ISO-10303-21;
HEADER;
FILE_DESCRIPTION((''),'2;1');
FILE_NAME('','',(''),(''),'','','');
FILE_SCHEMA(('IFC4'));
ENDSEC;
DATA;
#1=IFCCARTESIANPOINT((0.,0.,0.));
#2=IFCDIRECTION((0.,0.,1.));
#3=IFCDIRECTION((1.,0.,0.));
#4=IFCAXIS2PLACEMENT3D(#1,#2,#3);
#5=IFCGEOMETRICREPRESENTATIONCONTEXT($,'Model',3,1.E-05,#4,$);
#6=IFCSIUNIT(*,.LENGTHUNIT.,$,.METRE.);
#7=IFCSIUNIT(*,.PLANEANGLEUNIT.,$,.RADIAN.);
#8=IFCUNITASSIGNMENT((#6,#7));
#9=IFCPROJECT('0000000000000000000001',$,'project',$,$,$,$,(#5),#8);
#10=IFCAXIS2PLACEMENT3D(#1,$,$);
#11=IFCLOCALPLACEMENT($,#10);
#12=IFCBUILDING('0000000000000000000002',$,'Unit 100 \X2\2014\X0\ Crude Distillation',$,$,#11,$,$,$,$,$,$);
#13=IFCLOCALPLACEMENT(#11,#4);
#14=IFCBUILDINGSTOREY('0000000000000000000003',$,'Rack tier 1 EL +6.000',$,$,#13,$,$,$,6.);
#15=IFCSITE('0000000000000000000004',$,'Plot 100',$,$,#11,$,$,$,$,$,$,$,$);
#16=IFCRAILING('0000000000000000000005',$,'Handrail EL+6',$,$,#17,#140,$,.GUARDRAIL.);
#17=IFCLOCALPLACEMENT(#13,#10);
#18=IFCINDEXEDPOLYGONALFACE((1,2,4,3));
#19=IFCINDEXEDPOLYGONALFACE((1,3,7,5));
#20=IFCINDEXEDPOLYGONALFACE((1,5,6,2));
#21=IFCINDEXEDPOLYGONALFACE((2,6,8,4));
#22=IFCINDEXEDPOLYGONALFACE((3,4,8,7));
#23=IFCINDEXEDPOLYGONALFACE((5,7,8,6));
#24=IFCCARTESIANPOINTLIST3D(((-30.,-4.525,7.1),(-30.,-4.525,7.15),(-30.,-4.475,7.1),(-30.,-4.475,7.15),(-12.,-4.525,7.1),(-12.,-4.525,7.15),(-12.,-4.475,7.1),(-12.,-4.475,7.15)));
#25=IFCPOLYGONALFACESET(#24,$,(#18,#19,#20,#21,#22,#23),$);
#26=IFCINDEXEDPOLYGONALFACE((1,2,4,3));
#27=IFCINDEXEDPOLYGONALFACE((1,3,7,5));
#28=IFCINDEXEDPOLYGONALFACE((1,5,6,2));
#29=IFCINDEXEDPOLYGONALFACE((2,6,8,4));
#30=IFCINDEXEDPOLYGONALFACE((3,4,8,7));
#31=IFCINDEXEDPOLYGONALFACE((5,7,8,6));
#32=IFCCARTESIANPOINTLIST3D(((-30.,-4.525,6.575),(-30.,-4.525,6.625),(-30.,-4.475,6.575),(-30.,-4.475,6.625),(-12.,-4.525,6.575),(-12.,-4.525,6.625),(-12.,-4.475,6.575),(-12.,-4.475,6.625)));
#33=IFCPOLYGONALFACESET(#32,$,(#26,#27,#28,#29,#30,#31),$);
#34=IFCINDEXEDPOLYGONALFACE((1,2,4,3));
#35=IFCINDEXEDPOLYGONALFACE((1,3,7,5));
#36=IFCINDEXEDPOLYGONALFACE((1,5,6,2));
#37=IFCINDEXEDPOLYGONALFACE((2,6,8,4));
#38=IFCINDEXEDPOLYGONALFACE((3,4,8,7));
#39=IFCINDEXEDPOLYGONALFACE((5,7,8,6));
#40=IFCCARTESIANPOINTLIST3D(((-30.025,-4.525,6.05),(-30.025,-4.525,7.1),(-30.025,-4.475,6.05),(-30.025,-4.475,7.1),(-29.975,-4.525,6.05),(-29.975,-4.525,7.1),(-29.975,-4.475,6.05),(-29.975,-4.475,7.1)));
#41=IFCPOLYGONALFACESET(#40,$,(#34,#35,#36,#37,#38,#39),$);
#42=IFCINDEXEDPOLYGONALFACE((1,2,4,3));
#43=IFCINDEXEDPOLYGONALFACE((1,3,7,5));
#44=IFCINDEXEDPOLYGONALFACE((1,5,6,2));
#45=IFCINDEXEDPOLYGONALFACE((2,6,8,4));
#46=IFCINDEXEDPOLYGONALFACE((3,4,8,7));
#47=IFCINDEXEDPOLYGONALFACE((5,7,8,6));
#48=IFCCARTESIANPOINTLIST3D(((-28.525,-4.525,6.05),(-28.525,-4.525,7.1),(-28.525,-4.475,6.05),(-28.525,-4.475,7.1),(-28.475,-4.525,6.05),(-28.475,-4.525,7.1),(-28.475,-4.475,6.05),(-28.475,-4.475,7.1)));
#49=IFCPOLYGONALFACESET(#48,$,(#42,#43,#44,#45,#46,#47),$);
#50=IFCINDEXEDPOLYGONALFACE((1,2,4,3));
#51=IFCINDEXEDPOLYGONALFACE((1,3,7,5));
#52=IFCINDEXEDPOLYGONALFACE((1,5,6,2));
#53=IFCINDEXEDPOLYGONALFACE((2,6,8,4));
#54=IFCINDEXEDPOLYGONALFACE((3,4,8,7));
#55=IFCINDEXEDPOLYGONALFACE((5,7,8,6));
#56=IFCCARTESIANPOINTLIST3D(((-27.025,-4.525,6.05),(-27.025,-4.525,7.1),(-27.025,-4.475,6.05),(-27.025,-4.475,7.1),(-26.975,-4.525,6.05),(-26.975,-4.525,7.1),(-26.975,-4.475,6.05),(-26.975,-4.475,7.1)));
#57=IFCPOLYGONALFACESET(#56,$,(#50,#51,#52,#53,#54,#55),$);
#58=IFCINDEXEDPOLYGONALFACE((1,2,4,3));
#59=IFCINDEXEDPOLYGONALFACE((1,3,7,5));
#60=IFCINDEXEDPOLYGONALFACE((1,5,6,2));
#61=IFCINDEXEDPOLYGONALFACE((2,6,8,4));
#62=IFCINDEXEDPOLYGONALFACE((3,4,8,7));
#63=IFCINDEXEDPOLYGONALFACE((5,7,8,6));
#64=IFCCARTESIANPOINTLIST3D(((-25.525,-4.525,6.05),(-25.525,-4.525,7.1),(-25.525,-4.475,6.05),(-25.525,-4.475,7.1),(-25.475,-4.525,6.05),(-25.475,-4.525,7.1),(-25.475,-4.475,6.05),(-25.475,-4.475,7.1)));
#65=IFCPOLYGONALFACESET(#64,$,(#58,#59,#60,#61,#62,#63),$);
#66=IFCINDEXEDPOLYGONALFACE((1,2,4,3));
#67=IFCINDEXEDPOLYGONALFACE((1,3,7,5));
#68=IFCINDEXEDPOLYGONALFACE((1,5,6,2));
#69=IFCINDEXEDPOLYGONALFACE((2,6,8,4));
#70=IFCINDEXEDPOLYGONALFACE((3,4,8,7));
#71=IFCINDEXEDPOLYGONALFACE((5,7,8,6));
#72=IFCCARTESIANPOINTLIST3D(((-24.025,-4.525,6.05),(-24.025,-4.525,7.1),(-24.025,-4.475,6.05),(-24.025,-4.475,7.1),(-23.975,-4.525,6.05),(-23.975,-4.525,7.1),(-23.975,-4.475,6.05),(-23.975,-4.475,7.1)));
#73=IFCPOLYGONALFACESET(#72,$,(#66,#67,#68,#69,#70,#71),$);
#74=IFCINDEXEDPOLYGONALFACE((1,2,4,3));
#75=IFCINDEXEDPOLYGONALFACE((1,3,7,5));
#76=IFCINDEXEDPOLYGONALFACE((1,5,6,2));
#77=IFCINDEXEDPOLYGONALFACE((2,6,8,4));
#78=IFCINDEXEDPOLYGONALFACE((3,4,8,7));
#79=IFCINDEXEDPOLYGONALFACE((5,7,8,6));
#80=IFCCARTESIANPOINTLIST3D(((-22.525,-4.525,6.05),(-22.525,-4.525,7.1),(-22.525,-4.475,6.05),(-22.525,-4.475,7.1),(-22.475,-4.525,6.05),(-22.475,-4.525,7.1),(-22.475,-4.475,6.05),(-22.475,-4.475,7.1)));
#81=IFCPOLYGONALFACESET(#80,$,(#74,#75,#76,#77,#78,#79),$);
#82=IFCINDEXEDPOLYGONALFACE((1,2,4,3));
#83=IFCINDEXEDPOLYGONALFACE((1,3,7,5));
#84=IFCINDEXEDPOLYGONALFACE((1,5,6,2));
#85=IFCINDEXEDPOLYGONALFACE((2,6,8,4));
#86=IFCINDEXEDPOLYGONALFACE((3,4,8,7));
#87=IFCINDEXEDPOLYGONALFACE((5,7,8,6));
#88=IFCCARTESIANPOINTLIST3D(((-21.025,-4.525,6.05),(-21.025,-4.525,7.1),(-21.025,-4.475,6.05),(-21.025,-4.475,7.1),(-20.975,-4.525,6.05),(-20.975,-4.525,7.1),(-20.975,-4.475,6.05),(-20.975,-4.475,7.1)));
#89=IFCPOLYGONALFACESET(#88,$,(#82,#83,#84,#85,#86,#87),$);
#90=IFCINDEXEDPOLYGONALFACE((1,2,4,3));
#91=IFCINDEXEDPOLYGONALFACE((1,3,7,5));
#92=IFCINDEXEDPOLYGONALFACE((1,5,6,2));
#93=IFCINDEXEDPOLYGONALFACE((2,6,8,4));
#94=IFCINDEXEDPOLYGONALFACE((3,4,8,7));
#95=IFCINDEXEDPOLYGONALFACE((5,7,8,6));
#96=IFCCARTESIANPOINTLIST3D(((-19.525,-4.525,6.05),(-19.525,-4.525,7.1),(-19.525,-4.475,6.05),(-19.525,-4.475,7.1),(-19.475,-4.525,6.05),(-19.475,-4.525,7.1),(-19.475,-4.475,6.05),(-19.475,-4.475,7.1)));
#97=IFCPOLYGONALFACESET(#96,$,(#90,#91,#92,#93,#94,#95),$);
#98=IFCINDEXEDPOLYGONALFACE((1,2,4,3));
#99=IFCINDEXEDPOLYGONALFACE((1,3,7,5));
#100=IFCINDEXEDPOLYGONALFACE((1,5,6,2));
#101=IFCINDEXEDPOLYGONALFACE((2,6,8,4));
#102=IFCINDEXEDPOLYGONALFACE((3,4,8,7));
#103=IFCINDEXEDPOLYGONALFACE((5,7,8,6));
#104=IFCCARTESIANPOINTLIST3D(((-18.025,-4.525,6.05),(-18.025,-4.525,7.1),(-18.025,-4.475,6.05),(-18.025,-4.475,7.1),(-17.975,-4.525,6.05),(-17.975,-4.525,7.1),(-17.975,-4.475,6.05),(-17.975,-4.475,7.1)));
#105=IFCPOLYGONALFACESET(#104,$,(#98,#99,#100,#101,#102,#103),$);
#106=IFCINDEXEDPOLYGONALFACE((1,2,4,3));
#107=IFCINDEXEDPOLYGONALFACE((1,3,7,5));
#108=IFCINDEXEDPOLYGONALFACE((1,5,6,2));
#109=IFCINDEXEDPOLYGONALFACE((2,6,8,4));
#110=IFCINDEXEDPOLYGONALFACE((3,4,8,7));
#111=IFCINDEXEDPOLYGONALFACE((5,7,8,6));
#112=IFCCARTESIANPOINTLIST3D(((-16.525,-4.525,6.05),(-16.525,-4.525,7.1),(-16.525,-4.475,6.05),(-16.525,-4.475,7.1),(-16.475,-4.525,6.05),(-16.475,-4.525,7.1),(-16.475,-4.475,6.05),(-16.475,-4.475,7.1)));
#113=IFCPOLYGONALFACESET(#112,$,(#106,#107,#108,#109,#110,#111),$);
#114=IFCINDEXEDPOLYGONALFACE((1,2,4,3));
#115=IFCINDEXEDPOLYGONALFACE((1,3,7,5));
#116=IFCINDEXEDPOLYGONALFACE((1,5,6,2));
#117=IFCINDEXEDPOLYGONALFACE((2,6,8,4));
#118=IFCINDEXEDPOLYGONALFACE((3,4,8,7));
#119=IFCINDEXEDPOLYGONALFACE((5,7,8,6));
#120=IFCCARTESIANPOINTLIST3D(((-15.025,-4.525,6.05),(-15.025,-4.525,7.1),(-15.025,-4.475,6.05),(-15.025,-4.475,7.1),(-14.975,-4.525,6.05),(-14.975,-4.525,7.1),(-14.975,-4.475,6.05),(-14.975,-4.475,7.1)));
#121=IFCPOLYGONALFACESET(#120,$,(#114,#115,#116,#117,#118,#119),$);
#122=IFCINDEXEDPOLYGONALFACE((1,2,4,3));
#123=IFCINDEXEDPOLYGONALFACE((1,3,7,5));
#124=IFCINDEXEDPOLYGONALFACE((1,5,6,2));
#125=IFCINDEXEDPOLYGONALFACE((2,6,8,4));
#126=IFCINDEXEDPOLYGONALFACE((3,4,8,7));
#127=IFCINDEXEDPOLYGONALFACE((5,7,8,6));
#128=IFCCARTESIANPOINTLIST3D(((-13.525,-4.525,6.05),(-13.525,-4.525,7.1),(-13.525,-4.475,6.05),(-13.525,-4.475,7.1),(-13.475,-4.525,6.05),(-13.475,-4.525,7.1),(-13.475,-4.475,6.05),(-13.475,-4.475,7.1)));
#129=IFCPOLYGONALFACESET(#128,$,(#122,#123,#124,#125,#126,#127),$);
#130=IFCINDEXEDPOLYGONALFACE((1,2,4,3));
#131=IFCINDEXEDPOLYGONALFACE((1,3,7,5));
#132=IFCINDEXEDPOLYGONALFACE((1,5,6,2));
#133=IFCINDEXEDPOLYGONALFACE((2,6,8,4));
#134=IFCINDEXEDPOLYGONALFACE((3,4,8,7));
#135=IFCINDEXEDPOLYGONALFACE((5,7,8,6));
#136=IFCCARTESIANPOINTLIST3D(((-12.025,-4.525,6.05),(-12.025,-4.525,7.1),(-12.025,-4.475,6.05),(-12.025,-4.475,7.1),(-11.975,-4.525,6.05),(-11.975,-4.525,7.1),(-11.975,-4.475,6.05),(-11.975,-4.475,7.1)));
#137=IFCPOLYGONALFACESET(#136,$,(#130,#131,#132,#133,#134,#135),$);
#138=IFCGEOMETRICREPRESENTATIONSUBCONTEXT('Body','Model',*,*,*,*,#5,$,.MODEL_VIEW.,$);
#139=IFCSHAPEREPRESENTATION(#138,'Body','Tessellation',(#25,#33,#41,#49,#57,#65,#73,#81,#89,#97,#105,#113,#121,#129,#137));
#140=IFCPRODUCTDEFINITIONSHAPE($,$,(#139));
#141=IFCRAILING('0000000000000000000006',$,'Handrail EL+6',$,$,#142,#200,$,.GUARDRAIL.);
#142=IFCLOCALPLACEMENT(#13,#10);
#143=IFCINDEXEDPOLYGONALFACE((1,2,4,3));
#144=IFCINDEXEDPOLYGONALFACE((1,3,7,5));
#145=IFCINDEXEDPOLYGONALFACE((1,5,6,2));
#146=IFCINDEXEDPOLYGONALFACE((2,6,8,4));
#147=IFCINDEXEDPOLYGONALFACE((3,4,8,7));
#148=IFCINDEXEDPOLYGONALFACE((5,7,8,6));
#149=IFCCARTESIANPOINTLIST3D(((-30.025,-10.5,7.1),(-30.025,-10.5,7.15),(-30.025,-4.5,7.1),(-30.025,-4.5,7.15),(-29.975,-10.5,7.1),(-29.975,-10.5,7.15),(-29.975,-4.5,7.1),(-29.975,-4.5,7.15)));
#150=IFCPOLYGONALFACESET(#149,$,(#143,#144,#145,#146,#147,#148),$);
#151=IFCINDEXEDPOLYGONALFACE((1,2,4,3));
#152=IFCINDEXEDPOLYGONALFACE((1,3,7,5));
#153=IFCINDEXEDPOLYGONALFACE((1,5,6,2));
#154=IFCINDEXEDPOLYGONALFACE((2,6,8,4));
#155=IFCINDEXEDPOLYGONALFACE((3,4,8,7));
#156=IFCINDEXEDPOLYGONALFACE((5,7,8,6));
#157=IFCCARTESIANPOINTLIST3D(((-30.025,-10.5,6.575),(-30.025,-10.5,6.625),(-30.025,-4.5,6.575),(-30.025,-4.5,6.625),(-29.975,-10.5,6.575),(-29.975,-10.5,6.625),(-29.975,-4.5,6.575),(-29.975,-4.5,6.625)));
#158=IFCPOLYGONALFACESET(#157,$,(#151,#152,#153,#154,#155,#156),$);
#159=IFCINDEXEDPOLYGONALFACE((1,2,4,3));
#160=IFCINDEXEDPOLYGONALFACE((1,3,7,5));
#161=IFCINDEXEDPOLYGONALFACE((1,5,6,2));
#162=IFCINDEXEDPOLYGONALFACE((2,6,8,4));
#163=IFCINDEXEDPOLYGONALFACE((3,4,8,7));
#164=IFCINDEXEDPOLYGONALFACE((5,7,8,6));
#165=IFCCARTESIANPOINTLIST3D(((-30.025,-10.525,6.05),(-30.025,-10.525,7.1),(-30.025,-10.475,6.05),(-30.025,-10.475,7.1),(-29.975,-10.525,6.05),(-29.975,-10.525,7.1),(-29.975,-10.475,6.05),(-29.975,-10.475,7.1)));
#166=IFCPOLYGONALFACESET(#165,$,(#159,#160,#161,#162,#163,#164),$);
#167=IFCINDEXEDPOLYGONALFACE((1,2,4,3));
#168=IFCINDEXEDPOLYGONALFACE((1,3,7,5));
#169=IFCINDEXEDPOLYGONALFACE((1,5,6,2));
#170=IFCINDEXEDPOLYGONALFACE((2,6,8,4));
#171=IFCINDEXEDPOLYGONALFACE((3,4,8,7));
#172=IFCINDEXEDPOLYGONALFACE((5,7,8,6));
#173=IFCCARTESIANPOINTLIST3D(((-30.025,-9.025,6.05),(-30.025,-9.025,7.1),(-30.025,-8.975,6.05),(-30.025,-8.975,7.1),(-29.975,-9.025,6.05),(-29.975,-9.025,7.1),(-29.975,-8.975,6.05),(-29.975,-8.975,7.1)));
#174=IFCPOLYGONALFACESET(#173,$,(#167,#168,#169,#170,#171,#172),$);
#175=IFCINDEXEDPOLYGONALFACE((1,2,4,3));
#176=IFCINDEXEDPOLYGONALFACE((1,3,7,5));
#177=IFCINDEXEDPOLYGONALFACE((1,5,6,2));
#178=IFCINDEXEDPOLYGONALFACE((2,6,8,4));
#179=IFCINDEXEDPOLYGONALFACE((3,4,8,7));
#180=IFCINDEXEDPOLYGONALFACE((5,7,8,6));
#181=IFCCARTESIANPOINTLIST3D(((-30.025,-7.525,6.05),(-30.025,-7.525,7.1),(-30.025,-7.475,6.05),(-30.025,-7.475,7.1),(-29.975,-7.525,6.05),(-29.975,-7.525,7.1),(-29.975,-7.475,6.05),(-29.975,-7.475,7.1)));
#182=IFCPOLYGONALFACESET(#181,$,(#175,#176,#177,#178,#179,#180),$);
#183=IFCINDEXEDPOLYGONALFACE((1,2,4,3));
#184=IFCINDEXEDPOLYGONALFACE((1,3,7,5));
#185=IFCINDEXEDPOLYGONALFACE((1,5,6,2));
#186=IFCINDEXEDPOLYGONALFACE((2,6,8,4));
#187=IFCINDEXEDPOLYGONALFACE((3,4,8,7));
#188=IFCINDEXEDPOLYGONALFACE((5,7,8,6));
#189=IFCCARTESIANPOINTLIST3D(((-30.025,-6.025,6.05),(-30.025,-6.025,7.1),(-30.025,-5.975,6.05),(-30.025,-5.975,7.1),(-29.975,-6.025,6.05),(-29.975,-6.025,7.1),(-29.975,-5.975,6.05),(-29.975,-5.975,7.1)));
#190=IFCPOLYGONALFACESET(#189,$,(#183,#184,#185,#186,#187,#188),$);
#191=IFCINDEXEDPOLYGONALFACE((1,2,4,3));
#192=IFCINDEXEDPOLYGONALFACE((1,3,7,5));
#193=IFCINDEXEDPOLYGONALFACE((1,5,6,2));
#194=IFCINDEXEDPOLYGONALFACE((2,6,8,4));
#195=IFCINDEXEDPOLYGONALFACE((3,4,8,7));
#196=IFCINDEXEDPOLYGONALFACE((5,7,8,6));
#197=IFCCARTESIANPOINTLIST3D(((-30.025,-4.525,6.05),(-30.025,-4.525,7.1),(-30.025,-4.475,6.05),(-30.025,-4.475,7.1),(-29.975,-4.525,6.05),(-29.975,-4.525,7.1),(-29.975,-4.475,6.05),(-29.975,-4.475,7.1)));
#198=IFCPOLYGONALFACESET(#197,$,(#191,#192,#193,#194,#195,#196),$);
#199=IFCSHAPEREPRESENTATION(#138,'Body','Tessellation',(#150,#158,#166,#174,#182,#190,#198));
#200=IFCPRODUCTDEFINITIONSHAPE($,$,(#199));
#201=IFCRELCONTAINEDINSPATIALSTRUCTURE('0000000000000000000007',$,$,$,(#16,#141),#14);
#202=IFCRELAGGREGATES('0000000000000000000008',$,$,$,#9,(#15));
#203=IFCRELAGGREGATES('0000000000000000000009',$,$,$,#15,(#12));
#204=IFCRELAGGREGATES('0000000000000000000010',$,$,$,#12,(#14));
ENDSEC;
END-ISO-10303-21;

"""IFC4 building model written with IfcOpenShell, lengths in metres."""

from ifc_helpers import new_model, si_unit, frame, origin, origin_with_axes, origin_2d, place, context, subcontext, project, spatial, rectangle, extrude, element, save


model = new_model("IFC4")

# Units and contexts
model_context = context("Model", 3, precision=1e-05, world=origin_with_axes())
body_context = subcontext(model_context, "Body", "Model", "MODEL_VIEW")
ifc_project = project(units=[si_unit("LENGTHUNIT", "METRE"), si_unit("PLANEANGLEUNIT", "RADIAN")], contexts=[model_context])

# Site, building, storey
placement = place(None, origin())
site = spatial("IfcSite", under=ifc_project, at=placement, Name="Plot 100")
building = spatial("IfcBuilding", under=site, at=placement, Name="Unit 100 — Crude Distillation")
storey_placement = place(placement, origin_with_axes())
storey = spatial("IfcBuildingStorey", under=building, at=storey_placement, Name="Rack tier 1 EL +6.000", Elevation=6.0)

# Railings
railing_1_placement = place(storey_placement, origin_with_axes())
element("IfcRailing", 1, at=railing_1_placement, inside=storey, Name="Handrail EL+6", PredefinedType="GUARDRAIL", context=body_context, shape_type="SweptSolid", body=[
    extrude(rectangle(XDim=0.05, YDim=0.05, at=origin_2d()), frame((-30.0, -4.5, 7.125), z_axis=(1.0, 0.0, 0.0), x_axis=(0.0, 1.0, 0.0)), (0.0, 0.0, 1.0), 18.0),
    extrude(rectangle(XDim=0.05, YDim=0.05, at=origin_2d()), frame((-30.0, -4.5, 6.6), z_axis=(1.0, 0.0, 0.0), x_axis=(0.0, 1.0, 0.0)), (0.0, 0.0, 1.0), 18.0),
    extrude(rectangle(XDim=0.05, YDim=0.05, at=origin_2d()), frame((-30.0, -4.5, 6.05), z_axis=(0.0, 0.0, 1.0), x_axis=(1.0, 0.0, 0.0)), (0.0, 0.0, 1.0), 1.05),
    extrude(rectangle(XDim=0.05, YDim=0.05, at=origin_2d()), frame((-28.5, -4.5, 6.05), z_axis=(0.0, 0.0, 1.0), x_axis=(1.0, 0.0, 0.0)), (0.0, 0.0, 1.0), 1.05),
    extrude(rectangle(XDim=0.05, YDim=0.05, at=origin_2d()), frame((-27.0, -4.5, 6.05), z_axis=(0.0, 0.0, 1.0), x_axis=(1.0, 0.0, 0.0)), (0.0, 0.0, 1.0), 1.05),
    extrude(rectangle(XDim=0.05, YDim=0.05, at=origin_2d()), frame((-25.5, -4.5, 6.05), z_axis=(0.0, 0.0, 1.0), x_axis=(1.0, 0.0, 0.0)), (0.0, 0.0, 1.0), 1.05),
    extrude(rectangle(XDim=0.05, YDim=0.05, at=origin_2d()), frame((-24.0, -4.5, 6.05), z_axis=(0.0, 0.0, 1.0), x_axis=(1.0, 0.0, 0.0)), (0.0, 0.0, 1.0), 1.05),
    extrude(rectangle(XDim=0.05, YDim=0.05, at=origin_2d()), frame((-22.5, -4.5, 6.05), z_axis=(0.0, 0.0, 1.0), x_axis=(1.0, 0.0, 0.0)), (0.0, 0.0, 1.0), 1.05),
    extrude(rectangle(XDim=0.05, YDim=0.05, at=origin_2d()), frame((-21.0, -4.5, 6.05), z_axis=(0.0, 0.0, 1.0), x_axis=(1.0, 0.0, 0.0)), (0.0, 0.0, 1.0), 1.05),
    extrude(rectangle(XDim=0.05, YDim=0.05, at=origin_2d()), frame((-19.5, -4.5, 6.05), z_axis=(0.0, 0.0, 1.0), x_axis=(1.0, 0.0, 0.0)), (0.0, 0.0, 1.0), 1.05),
    extrude(rectangle(XDim=0.05, YDim=0.05, at=origin_2d()), frame((-18.0, -4.5, 6.05), z_axis=(0.0, 0.0, 1.0), x_axis=(1.0, 0.0, 0.0)), (0.0, 0.0, 1.0), 1.05),
    extrude(rectangle(XDim=0.05, YDim=0.05, at=origin_2d()), frame((-16.5, -4.5, 6.05), z_axis=(0.0, 0.0, 1.0), x_axis=(1.0, 0.0, 0.0)), (0.0, 0.0, 1.0), 1.05),
    extrude(rectangle(XDim=0.05, YDim=0.05, at=origin_2d()), frame((-15.0, -4.5, 6.05), z_axis=(0.0, 0.0, 1.0), x_axis=(1.0, 0.0, 0.0)), (0.0, 0.0, 1.0), 1.05),
    extrude(rectangle(XDim=0.05, YDim=0.05, at=origin_2d()), frame((-13.5, -4.5, 6.05), z_axis=(0.0, 0.0, 1.0), x_axis=(1.0, 0.0, 0.0)), (0.0, 0.0, 1.0), 1.05),
    extrude(rectangle(XDim=0.05, YDim=0.05, at=origin_2d()), frame((-12.0, -4.5, 6.05), z_axis=(0.0, 0.0, 1.0), x_axis=(1.0, 0.0, 0.0)), (0.0, 0.0, 1.0), 1.05),
])
railing_2_placement = place(storey_placement, origin_with_axes())
element("IfcRailing", 2, at=railing_2_placement, inside=storey, Name="Handrail EL+6", PredefinedType="GUARDRAIL", context=body_context, shape_type="SweptSolid", body=[
    extrude(rectangle(XDim=0.05, YDim=0.05, at=origin_2d()), frame((-30.0, -10.5, 7.125), z_axis=(0.0, 1.0, 0.0), x_axis=(-1.0, 0.0, 0.0)), (0.0, 0.0, 1.0), 6.0),
    extrude(rectangle(XDim=0.05, YDim=0.05, at=origin_2d()), frame((-30.0, -10.5, 6.6), z_axis=(0.0, 1.0, 0.0), x_axis=(-1.0, 0.0, 0.0)), (0.0, 0.0, 1.0), 6.0),
    extrude(rectangle(XDim=0.05, YDim=0.05, at=origin_2d()), frame((-30.0, -10.5, 6.05), z_axis=(0.0, 0.0, 1.0), x_axis=(1.0, 0.0, 0.0)), (0.0, 0.0, 1.0), 1.05),
    extrude(rectangle(XDim=0.05, YDim=0.05, at=origin_2d()), frame((-30.0, -9.0, 6.05), z_axis=(0.0, 0.0, 1.0), x_axis=(1.0, 0.0, 0.0)), (0.0, 0.0, 1.0), 1.05),
    extrude(rectangle(XDim=0.05, YDim=0.05, at=origin_2d()), frame((-30.0, -7.5, 6.05), z_axis=(0.0, 0.0, 1.0), x_axis=(1.0, 0.0, 0.0)), (0.0, 0.0, 1.0), 1.05),
    extrude(rectangle(XDim=0.05, YDim=0.05, at=origin_2d()), frame((-30.0, -6.0, 6.05), z_axis=(0.0, 0.0, 1.0), x_axis=(1.0, 0.0, 0.0)), (0.0, 0.0, 1.0), 1.05),
    extrude(rectangle(XDim=0.05, YDim=0.05, at=origin_2d()), frame((-30.0, -4.5, 6.05), z_axis=(0.0, 0.0, 1.0), x_axis=(1.0, 0.0, 0.0)), (0.0, 0.0, 1.0), 1.05),
])

save(model, "model.ifc")
